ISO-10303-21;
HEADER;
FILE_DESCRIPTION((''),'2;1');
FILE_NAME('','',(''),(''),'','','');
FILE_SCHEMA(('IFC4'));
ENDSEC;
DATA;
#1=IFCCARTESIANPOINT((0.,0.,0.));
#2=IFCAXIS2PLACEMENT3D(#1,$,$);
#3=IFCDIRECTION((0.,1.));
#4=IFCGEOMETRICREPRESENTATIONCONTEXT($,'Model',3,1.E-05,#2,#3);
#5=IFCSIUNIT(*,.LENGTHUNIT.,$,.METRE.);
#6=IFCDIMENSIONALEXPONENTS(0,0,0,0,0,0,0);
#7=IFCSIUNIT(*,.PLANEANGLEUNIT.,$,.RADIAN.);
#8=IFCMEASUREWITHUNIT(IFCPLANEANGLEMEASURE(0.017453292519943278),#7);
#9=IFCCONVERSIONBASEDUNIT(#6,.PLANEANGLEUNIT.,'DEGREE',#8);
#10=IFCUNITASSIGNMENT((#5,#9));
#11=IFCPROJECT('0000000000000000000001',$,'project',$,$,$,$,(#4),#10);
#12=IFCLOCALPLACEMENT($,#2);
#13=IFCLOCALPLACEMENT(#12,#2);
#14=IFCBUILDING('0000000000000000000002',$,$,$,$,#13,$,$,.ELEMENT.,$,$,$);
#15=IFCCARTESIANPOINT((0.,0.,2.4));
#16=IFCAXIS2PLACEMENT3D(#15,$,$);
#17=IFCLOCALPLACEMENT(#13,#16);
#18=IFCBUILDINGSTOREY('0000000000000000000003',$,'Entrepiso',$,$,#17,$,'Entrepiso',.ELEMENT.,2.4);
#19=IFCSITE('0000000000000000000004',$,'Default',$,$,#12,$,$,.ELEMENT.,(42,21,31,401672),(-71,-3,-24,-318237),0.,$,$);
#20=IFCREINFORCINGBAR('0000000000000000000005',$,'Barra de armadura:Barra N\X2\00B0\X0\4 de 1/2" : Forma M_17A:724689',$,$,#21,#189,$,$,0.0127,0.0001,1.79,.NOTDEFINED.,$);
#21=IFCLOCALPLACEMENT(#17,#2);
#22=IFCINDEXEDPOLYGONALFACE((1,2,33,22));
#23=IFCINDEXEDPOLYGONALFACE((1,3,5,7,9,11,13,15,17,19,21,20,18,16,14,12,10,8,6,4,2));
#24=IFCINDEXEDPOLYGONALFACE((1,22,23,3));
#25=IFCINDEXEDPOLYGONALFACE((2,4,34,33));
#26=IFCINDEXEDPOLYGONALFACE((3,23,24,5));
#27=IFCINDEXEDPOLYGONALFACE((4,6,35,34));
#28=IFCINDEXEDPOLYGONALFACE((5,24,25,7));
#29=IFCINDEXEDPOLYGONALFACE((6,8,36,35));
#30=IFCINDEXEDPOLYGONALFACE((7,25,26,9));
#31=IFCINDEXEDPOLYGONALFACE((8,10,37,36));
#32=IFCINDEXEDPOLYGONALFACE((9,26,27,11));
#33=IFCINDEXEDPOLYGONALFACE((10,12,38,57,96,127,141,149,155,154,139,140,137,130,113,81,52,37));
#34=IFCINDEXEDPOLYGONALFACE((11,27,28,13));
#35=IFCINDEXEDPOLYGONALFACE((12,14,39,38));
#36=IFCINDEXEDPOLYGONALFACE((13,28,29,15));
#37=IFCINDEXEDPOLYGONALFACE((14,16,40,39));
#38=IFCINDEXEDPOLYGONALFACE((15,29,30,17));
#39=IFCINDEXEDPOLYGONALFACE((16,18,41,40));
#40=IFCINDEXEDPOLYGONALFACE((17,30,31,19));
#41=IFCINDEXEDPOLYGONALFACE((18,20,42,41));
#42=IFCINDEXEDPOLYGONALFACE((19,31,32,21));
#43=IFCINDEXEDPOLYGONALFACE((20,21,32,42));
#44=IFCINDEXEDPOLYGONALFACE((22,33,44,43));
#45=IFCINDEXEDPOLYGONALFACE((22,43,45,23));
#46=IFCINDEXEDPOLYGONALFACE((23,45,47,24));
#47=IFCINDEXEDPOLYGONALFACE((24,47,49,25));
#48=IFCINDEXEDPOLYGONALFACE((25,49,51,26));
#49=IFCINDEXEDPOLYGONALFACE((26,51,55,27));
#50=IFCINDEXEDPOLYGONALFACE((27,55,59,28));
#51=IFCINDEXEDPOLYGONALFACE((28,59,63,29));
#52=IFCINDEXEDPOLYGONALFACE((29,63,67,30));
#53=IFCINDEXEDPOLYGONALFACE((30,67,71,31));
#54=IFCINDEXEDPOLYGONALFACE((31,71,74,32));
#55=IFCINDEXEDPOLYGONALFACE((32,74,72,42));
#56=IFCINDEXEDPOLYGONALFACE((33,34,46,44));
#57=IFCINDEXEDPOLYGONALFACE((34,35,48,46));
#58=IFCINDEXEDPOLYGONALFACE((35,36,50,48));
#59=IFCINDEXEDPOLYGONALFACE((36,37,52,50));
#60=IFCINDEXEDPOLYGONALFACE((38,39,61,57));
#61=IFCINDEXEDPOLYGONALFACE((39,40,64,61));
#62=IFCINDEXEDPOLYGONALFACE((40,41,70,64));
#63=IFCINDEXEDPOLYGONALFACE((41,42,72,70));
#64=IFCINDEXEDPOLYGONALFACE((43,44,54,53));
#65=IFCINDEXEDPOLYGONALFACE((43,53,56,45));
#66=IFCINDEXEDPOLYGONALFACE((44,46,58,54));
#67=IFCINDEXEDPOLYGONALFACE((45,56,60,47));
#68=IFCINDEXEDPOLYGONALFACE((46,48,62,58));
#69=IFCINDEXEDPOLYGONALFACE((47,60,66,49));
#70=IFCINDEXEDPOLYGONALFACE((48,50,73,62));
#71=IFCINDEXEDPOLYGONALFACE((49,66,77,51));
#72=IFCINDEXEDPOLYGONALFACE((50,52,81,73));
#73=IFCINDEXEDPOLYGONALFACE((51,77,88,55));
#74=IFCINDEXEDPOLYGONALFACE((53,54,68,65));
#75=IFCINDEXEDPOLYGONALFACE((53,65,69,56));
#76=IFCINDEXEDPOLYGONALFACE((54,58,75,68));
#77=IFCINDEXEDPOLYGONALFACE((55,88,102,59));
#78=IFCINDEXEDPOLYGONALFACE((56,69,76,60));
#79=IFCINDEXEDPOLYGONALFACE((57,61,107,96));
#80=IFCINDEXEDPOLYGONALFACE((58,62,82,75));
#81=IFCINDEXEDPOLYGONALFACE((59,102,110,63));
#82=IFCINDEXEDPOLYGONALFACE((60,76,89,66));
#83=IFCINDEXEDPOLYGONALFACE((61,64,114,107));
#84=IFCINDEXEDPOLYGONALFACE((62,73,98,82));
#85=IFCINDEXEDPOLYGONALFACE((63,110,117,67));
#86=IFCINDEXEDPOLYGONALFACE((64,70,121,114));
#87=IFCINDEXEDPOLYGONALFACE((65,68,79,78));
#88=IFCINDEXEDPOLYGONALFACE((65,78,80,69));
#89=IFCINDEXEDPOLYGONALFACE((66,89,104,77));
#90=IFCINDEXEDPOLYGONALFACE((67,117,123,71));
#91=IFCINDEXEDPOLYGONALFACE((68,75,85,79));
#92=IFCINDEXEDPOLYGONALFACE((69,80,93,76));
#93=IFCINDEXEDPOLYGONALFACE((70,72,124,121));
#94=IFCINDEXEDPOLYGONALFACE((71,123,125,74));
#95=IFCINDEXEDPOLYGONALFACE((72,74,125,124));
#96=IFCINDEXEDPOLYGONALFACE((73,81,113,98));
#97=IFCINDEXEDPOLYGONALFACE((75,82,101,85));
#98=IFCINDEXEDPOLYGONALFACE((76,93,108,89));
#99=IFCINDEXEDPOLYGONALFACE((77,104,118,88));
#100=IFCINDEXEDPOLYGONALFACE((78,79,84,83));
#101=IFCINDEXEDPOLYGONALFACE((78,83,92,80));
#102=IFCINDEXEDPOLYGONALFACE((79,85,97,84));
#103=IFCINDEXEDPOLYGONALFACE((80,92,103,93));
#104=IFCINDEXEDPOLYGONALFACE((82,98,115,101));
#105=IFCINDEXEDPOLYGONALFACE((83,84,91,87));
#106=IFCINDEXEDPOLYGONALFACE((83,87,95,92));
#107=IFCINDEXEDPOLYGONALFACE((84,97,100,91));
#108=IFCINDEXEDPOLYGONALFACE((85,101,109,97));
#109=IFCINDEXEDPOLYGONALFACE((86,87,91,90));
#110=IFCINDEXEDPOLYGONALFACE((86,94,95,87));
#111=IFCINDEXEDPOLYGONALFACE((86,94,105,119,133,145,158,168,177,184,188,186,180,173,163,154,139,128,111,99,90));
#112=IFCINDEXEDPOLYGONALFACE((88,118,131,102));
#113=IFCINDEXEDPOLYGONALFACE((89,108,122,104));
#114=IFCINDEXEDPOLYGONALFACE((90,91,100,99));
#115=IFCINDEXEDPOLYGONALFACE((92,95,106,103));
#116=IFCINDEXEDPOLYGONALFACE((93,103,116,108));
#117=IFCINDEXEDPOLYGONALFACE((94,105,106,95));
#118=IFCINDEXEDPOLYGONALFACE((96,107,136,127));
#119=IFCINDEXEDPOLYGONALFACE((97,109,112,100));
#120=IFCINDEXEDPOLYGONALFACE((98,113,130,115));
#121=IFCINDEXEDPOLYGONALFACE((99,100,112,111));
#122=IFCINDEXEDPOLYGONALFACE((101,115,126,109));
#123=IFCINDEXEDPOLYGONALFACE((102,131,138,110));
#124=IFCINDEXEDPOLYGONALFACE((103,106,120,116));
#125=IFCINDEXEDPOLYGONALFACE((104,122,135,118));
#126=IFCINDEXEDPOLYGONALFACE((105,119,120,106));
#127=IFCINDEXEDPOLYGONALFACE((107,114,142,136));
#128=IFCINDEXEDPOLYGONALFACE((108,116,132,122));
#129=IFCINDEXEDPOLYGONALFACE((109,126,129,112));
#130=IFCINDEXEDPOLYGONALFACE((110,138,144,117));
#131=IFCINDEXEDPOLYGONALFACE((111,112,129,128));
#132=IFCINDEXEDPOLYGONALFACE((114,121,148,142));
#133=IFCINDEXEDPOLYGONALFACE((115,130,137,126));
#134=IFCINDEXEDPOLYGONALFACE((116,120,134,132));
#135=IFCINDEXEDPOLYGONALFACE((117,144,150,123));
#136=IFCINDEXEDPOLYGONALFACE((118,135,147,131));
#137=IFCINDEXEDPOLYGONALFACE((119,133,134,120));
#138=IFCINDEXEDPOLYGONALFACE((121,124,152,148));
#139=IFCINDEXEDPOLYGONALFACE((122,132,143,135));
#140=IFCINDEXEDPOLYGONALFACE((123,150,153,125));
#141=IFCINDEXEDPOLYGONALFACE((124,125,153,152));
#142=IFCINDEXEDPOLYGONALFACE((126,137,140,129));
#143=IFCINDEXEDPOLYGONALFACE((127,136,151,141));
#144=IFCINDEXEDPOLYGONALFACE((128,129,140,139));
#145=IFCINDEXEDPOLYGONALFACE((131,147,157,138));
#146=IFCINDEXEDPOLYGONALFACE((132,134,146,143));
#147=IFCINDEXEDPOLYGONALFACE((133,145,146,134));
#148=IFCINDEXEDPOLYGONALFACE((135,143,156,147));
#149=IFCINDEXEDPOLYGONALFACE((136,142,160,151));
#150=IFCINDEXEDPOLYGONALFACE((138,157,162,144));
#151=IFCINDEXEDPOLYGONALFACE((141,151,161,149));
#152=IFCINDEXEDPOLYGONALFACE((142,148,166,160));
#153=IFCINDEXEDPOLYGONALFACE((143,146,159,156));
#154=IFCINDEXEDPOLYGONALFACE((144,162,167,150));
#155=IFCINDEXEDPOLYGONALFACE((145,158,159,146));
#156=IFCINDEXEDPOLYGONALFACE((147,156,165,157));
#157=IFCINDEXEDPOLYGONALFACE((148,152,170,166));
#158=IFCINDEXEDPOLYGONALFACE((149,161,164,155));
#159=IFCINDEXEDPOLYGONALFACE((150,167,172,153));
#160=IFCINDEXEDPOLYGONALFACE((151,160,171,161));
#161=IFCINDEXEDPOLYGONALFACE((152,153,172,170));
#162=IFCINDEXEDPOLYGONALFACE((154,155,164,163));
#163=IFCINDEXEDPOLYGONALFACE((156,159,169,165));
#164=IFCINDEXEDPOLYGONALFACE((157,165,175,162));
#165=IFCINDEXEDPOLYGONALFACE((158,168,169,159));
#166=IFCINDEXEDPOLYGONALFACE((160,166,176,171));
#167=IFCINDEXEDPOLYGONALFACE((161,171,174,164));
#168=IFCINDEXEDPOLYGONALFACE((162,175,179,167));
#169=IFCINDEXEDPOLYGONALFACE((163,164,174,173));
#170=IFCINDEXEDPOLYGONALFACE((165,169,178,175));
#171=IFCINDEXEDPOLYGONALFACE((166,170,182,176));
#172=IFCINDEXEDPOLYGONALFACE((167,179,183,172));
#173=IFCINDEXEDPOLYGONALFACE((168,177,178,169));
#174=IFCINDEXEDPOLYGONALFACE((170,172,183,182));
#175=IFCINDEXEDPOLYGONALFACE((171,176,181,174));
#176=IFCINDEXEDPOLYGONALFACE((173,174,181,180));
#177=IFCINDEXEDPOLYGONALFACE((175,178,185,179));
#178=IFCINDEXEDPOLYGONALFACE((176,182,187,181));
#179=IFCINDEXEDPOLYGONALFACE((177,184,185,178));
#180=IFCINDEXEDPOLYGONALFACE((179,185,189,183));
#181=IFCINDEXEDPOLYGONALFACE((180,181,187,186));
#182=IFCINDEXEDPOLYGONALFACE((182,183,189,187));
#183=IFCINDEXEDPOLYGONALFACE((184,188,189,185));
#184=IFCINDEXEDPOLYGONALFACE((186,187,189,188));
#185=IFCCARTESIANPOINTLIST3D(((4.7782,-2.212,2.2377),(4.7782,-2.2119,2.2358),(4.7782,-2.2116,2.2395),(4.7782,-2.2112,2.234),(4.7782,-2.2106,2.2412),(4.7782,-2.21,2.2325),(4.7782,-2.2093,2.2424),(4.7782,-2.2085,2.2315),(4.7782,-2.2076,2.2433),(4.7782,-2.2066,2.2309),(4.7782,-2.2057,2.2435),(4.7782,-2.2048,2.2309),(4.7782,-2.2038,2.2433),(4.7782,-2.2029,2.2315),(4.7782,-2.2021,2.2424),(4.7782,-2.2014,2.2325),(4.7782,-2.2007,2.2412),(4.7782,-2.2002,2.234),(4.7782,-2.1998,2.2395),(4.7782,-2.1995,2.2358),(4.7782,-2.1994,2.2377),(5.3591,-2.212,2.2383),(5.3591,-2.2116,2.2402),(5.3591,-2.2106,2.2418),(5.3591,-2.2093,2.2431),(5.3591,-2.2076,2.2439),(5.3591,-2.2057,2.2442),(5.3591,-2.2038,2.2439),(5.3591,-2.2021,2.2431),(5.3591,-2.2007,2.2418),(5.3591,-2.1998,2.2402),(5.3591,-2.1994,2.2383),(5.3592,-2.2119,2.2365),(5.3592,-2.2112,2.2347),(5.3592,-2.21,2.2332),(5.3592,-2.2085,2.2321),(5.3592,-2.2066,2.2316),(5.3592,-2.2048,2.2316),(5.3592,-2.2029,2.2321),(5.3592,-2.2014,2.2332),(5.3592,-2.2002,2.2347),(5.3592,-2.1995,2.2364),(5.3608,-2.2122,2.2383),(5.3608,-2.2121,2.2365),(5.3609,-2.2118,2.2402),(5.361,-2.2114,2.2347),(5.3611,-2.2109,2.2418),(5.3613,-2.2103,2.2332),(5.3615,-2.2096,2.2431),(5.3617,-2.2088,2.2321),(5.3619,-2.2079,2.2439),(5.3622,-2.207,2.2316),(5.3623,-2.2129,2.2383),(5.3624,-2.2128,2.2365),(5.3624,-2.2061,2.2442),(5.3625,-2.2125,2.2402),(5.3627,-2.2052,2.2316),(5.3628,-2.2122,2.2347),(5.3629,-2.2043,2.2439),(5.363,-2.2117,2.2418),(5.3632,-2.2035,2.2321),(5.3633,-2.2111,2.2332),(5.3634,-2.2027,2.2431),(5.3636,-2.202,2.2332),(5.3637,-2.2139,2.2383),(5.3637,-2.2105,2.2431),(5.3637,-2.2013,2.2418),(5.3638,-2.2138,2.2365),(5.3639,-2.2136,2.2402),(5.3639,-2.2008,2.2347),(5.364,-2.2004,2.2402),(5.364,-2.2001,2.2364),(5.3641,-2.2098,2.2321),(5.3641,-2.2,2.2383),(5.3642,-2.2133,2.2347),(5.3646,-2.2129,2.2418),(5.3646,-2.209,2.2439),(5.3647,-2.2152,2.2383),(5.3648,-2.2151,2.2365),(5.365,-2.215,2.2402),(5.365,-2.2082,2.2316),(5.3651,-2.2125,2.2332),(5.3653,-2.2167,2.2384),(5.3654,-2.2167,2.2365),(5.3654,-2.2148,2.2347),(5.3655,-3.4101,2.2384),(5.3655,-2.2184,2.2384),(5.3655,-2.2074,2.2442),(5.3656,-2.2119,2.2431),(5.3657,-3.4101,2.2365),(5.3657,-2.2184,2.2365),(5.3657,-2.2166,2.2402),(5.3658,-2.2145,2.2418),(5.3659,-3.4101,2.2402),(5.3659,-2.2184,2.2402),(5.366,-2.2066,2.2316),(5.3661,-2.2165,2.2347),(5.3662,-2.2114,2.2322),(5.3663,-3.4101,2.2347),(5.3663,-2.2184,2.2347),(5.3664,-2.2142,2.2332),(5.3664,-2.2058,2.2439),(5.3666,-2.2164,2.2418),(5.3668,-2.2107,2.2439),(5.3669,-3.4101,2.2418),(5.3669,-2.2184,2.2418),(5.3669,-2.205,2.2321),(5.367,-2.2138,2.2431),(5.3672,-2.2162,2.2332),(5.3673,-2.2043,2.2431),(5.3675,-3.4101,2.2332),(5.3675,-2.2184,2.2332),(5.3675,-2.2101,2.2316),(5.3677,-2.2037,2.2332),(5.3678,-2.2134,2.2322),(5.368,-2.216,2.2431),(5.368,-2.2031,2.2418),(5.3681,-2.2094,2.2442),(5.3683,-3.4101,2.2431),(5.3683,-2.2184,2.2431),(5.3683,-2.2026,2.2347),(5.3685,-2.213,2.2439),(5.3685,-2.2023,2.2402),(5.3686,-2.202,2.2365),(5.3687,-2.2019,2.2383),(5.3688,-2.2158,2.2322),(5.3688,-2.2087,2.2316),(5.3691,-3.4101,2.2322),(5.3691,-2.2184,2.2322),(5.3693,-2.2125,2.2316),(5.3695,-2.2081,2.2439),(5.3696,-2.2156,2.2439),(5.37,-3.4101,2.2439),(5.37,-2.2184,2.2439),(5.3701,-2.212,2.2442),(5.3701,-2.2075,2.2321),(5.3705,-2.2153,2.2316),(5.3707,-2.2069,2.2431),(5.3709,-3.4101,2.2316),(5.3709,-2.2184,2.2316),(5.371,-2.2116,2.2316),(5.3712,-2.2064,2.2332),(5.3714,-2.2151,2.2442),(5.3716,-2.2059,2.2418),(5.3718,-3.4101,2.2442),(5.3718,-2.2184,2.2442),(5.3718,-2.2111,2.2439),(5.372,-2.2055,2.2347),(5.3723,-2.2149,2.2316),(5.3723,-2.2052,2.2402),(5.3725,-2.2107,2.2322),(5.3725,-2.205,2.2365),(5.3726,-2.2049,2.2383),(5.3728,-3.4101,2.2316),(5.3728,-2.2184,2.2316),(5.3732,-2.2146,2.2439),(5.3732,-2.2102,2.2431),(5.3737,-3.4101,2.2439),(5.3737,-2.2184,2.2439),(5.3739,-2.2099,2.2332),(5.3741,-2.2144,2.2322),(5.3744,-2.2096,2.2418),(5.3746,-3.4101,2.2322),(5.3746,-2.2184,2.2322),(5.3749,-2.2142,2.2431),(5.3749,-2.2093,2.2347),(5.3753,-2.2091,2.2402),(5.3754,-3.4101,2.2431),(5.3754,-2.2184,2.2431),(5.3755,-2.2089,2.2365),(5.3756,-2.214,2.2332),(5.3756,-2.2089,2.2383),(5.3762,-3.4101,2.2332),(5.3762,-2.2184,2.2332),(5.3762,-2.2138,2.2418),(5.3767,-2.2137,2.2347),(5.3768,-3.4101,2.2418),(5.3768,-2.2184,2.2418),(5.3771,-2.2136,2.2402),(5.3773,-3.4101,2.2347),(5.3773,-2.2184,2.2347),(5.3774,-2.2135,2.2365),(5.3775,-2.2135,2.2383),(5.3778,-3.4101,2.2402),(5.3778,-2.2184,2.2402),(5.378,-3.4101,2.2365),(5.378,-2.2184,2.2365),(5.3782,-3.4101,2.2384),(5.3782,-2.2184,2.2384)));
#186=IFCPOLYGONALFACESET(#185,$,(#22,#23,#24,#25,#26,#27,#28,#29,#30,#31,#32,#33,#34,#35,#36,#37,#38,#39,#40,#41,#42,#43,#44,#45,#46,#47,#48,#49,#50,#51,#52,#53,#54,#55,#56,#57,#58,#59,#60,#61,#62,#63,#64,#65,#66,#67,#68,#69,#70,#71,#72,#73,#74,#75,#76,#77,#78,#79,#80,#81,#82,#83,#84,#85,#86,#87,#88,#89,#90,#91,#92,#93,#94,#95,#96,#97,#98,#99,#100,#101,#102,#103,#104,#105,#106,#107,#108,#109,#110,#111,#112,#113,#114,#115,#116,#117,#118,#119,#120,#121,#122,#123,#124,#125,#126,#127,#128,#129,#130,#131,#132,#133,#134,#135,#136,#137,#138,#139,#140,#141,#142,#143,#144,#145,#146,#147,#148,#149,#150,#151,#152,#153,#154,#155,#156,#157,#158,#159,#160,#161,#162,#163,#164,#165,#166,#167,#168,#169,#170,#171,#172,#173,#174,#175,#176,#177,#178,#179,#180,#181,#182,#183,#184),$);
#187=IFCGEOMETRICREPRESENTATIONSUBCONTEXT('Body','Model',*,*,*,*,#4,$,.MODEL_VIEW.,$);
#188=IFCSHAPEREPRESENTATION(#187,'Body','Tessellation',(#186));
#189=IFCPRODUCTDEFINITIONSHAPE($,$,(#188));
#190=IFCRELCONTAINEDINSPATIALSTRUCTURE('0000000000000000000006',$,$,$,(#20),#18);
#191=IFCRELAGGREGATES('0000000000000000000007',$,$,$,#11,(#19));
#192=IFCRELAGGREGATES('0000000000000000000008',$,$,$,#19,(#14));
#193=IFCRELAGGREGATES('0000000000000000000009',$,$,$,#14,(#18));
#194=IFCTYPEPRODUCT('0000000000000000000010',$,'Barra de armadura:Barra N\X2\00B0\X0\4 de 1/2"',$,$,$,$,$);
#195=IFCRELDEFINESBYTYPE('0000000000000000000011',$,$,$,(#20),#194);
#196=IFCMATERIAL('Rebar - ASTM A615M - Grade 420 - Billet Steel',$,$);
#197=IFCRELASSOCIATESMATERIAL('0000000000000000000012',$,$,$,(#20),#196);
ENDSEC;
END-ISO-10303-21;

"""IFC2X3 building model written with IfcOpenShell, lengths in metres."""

from ifc_helpers import new_model, entity, si_unit, converted_unit, direction, frame, origin, place, context, subcontext, project, spatial, material, type_object, element, save


model = new_model("IFC2X3")

# Units and contexts
model_context = context("Model", 3, precision=1e-05, world=origin(), true_north=direction((0.0, 1.0)))
body_context = subcontext(model_context, "Body", "Model", "MODEL_VIEW")
ifc_project = project(units=[si_unit("LENGTHUNIT", "METRE"), converted_unit("PLANEANGLEUNIT", "DEGREE", entity("IfcPlaneAngleMeasure", 0.017453292519943278), si_unit("PLANEANGLEUNIT", "RADIAN"), dimensions=[0, 0, 0, 0, 0, 0, 0])], contexts=[model_context])

# Site, building, storey
site_placement = place(None, origin())
site = spatial("IfcSite", under=ifc_project, at=site_placement, Name="Default", CompositionType="ELEMENT", RefLatitude=(42, 21, 31, 401672), RefLongitude=(-71, -3, -24, -318237), RefElevation=0.0)
building_placement = place(site_placement, origin())
building = spatial("IfcBuilding", under=site, at=building_placement, CompositionType="ELEMENT")
storey_placement = place(building_placement, frame((0.0, 0.0, 2.4)))
storey = spatial("IfcBuildingStorey", under=building, at=storey_placement, Name="Entrepiso", LongName="Entrepiso", CompositionType="ELEMENT", Elevation=2.4)

# Reinforcing bar
ifc_material = material(Name="Rebar - ASTM A615M - Grade 420 - Billet Steel")
type_product_1 = type_object("IfcTypeProduct", Name="Barra de armadura:Barra N°4 de 1/2\"")
reinforcing_bar_1_placement = place(storey_placement, origin())
element("IfcReinforcingBar", 1, at=reinforcing_bar_1_placement, inside=storey, type_object=type_product_1, material=ifc_material, Name="Barra de armadura:Barra N°4 de 1/2\" : Forma M_17A:724689", BarLength=1.79, BarRole="NOTDEFINED", CrossSectionArea=0.0001, NominalDiameter=0.0127, context=body_context, shape_type="AdvancedSweptSolid", body=[
    entity("IfcSweptDiskSolid", entity("IfcCompositeCurve", [entity("IfcCompositeCurveSegment", "CONTINUOUS", True, entity("IfcPolyline", [entity("IfcCartesianPoint", [5.3718, -3.4101, 2.2379]), entity("IfcCartesianPoint", [5.3718, -2.2184, 2.2379])])), entity("IfcCompositeCurveSegment", "CONTINUOUS", True, entity("IfcTrimmedCurve", entity("IfcCircle", entity("IfcAxis2Placement3D", entity("IfcCartesianPoint", [5.3591, -2.2184, 2.2379]), entity("IfcDirection", [-0.001144, 0.0, 0.999999]), entity("IfcDirection", [0.0, 1.0, 0.0])), 0.0127), [entity("IfcParameterValue", 270.0)], [entity("IfcParameterValue", 360.0)], True, "PARAMETER")), entity("IfcCompositeCurveSegment", "CONTINUOUS", True, entity("IfcPolyline", [entity("IfcCartesianPoint", [5.3591, -2.2057, 2.2379]), entity("IfcCartesianPoint", [4.7782, -2.2057, 2.2372])]))], False), 0.0063, None, 0.0, 92.0),
])

save(model, "model.ifc")
